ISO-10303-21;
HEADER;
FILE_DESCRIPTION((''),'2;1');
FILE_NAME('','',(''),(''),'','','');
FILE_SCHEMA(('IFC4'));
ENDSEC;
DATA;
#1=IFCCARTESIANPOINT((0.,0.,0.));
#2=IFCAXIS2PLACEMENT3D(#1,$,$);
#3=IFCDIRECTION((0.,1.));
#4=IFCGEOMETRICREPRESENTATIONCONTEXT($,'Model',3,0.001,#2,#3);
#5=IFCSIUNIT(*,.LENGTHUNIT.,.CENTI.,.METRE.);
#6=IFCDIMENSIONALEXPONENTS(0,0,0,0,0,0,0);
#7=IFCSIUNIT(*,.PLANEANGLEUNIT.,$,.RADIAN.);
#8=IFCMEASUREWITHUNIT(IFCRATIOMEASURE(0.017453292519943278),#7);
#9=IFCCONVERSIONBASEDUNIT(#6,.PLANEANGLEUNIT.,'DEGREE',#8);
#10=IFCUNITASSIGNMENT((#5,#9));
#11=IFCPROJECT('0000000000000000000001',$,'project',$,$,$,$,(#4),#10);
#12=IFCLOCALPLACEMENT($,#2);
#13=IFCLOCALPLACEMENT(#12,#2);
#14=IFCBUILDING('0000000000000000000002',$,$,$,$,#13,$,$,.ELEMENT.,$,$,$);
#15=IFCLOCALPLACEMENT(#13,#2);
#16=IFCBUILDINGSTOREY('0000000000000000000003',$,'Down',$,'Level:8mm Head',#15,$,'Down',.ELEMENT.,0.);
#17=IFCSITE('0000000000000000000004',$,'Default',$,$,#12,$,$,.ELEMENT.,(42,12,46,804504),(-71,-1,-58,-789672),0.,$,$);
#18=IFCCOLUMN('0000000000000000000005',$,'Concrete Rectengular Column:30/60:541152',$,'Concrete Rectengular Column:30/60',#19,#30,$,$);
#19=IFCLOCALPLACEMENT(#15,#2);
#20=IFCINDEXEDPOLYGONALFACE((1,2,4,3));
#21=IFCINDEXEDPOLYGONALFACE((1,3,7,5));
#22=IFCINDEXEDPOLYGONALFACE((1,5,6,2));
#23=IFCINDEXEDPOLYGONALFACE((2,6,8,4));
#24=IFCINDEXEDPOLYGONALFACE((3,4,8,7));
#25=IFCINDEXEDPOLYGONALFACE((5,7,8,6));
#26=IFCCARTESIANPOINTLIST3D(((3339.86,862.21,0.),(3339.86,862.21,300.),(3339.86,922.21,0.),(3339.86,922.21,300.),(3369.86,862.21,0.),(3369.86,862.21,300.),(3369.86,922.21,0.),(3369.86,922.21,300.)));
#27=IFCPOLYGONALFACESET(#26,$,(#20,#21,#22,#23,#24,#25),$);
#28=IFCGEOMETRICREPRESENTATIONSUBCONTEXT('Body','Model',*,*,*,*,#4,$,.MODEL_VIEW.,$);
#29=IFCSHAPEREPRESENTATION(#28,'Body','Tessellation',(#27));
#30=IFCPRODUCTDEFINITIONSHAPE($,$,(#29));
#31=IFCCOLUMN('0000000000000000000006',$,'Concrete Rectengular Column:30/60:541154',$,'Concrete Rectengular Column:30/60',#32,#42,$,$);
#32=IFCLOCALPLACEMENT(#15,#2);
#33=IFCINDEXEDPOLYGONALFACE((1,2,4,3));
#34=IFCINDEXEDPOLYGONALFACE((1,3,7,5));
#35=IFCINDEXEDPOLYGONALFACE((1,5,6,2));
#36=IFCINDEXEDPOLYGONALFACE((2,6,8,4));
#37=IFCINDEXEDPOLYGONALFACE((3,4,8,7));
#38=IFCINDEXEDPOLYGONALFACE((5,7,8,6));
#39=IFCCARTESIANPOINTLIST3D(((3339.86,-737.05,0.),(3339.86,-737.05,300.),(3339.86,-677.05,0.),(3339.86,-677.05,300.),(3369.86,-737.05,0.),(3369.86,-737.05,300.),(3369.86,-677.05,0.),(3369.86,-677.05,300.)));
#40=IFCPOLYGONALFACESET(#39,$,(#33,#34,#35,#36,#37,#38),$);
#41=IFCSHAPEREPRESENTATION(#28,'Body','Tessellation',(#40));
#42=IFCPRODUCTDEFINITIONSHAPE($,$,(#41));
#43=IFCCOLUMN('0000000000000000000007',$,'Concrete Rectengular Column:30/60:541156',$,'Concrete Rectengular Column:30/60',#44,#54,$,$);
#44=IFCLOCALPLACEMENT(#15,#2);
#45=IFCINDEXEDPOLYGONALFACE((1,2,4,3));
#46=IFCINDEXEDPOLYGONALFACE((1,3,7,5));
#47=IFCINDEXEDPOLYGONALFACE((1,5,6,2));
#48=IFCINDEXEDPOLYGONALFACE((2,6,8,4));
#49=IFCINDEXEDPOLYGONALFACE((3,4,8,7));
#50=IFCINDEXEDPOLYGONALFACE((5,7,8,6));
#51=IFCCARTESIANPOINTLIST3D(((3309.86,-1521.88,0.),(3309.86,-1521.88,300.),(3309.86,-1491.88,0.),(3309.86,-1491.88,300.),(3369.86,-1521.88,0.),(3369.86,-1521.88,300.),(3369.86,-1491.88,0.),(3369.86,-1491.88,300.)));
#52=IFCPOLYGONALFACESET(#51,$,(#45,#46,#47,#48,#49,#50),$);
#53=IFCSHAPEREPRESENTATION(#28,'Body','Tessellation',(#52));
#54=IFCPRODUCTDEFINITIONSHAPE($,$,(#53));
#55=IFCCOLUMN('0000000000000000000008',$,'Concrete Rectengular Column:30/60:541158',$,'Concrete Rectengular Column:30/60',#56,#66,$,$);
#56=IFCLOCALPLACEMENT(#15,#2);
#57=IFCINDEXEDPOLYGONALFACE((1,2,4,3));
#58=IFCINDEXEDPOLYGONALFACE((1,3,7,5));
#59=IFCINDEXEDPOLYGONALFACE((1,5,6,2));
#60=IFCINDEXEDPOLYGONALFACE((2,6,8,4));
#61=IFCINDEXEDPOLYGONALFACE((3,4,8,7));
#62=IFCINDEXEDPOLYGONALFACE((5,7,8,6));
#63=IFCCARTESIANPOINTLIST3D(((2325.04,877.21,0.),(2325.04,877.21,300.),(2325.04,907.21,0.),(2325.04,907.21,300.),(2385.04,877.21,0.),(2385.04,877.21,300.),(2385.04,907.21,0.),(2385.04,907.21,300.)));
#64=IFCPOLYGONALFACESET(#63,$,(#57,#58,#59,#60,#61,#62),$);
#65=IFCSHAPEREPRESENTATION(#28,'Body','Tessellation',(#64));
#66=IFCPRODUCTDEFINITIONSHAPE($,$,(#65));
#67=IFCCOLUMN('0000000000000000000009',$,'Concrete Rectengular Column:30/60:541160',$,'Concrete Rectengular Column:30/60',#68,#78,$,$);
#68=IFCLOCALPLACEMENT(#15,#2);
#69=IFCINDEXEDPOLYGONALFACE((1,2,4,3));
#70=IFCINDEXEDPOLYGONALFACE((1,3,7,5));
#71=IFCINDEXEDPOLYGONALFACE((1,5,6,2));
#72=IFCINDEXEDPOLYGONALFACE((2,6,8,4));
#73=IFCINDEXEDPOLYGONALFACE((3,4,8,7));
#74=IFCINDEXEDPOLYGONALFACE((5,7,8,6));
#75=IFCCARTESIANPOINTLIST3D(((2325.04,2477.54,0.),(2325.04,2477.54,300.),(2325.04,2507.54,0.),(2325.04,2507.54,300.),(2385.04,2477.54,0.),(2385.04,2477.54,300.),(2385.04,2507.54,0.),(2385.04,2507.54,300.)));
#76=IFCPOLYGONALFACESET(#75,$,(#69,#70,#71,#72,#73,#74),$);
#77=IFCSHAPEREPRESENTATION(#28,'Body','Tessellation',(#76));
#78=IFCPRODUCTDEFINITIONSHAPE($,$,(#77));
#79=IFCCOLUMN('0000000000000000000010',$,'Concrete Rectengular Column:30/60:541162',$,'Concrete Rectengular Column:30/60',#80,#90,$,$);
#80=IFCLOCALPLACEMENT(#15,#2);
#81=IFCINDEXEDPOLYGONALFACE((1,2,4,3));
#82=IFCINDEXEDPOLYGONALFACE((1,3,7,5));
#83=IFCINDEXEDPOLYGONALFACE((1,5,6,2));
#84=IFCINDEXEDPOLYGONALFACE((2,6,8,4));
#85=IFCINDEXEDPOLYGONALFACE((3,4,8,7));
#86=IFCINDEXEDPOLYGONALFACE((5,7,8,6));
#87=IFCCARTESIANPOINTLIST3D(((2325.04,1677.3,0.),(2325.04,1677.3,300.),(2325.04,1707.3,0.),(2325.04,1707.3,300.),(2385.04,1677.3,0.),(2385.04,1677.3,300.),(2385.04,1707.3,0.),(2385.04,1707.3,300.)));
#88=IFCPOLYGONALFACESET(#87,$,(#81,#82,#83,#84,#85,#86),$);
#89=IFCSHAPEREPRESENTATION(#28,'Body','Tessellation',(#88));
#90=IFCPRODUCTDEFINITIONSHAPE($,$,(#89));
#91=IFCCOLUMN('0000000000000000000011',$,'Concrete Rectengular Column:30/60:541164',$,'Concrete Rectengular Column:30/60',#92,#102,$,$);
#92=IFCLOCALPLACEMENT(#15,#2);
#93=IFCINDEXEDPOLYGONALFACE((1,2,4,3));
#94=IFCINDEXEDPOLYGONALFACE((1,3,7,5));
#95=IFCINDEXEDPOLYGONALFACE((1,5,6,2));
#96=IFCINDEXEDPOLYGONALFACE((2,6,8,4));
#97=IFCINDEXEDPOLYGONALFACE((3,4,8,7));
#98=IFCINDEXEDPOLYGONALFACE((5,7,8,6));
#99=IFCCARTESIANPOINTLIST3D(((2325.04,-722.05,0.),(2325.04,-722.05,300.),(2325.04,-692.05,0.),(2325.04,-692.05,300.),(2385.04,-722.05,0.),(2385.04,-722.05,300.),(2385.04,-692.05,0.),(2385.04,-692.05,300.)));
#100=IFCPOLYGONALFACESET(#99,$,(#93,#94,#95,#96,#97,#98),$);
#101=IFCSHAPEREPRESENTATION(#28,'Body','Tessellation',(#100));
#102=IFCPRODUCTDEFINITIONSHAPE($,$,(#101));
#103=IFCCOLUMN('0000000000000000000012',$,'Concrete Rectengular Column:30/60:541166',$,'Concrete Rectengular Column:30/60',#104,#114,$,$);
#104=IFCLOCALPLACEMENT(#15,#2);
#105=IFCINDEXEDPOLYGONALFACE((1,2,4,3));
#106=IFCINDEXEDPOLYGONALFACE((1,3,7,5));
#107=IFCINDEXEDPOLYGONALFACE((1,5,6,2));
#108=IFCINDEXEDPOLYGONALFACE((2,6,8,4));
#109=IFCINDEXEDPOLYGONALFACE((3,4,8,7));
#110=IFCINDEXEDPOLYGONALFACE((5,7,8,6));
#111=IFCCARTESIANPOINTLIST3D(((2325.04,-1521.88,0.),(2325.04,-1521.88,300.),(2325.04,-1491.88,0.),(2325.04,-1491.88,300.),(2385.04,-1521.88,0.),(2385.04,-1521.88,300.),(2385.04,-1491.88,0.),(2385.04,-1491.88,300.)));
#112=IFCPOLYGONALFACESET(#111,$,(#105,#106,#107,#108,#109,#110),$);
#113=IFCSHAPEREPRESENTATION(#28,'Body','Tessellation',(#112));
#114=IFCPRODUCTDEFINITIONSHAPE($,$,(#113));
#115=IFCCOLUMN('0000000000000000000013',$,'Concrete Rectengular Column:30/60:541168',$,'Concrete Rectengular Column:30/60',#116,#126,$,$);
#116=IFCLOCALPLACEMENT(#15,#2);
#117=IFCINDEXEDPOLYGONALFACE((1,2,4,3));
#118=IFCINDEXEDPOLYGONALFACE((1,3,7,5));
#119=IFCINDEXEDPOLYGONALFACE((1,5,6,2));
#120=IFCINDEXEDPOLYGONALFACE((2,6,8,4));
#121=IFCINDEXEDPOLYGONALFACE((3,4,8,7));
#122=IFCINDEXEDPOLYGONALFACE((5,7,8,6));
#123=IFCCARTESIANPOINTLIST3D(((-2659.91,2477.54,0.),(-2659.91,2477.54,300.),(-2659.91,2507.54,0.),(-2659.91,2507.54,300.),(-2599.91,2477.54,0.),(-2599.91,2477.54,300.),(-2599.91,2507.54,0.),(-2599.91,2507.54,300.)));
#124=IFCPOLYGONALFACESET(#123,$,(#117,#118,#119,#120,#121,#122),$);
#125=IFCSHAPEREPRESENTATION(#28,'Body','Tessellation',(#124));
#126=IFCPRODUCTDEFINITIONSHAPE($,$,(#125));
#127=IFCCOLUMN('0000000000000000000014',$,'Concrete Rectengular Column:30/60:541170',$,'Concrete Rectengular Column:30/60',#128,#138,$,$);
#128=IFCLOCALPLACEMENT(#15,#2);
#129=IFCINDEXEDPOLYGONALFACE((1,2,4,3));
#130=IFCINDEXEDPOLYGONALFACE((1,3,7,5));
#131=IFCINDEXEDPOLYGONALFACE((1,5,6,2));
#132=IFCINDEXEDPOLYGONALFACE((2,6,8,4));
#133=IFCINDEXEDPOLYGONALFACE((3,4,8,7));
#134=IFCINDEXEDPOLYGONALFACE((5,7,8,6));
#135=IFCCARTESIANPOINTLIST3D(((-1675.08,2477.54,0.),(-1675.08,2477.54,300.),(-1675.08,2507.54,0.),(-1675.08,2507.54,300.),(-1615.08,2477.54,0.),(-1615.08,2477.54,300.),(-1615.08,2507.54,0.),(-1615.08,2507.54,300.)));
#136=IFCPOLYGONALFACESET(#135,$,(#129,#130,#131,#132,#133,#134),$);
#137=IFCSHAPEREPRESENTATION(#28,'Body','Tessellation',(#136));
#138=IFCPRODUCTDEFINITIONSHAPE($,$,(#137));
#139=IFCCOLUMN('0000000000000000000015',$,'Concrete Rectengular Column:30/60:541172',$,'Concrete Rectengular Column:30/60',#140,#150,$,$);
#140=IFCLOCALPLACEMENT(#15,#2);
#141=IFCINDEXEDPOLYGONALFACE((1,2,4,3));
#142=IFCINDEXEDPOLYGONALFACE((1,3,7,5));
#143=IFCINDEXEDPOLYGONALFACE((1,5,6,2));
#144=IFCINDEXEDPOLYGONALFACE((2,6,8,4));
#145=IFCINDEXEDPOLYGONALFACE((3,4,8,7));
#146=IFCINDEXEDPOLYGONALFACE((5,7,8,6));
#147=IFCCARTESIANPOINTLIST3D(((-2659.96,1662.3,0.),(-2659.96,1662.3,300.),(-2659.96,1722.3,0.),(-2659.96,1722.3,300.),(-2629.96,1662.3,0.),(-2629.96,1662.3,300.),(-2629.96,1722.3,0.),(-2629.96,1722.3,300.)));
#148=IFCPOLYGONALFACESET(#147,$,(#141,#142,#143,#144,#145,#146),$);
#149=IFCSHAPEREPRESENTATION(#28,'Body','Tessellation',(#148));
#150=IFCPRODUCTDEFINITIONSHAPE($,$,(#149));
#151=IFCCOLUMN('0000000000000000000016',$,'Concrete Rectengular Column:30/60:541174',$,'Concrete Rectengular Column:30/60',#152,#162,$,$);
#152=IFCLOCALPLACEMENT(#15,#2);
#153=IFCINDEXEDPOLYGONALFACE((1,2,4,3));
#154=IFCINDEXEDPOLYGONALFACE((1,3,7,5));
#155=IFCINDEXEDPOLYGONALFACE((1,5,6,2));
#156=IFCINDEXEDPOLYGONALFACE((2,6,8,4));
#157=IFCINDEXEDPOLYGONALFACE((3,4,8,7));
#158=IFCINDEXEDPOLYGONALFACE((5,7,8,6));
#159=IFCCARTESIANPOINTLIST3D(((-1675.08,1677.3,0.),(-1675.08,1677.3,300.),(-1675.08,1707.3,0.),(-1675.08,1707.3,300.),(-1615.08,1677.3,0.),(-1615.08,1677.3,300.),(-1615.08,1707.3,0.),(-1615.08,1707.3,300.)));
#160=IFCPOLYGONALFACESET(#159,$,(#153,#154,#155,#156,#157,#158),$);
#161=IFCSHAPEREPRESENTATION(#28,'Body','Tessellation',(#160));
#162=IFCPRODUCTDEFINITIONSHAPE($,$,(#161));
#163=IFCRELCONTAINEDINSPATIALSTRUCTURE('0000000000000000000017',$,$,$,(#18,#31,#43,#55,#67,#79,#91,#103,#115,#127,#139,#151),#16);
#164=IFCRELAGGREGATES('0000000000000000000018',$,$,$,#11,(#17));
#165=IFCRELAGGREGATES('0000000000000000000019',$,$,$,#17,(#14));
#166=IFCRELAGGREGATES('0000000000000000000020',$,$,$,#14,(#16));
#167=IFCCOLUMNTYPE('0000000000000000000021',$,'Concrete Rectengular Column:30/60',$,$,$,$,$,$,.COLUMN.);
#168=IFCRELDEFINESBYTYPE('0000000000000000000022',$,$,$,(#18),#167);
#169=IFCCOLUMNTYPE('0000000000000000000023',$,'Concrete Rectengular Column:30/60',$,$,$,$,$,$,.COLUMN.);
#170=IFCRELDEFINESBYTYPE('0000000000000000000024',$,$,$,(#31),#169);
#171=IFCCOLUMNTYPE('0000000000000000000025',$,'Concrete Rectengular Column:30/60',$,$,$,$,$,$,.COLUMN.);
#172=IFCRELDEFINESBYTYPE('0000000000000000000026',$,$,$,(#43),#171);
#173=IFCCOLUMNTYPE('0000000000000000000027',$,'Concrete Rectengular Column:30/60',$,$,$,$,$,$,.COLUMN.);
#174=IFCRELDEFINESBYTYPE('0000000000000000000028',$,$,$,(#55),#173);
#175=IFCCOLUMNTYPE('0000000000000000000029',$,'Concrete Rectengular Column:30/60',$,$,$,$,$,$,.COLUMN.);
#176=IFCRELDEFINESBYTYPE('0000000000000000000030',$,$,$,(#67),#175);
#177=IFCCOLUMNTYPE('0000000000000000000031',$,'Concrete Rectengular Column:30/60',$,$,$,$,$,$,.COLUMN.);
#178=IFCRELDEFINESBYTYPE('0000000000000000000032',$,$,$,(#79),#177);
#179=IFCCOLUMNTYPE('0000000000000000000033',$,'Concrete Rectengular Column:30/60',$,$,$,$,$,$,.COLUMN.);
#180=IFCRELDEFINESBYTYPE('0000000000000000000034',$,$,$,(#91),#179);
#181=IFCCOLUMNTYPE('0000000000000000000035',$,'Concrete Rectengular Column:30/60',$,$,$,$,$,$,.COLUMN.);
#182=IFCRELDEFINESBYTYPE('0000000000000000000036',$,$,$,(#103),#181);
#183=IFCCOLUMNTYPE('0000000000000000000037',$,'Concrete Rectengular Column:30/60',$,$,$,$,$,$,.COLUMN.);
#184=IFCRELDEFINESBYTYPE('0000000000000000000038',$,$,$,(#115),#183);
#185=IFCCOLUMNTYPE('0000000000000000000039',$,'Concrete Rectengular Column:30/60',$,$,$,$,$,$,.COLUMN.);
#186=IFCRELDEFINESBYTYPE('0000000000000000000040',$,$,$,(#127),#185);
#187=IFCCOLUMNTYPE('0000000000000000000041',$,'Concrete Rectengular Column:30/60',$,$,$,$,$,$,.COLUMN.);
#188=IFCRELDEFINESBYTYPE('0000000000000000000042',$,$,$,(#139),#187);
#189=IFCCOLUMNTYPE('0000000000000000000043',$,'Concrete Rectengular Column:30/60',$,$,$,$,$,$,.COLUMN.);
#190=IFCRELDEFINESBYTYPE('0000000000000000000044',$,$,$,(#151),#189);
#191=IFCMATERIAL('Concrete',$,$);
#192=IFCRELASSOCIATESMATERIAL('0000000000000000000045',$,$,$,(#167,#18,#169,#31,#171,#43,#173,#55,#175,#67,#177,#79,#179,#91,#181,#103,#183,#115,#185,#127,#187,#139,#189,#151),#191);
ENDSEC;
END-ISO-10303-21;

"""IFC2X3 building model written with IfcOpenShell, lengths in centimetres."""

from ifc_helpers import new_model, entity, si_unit, converted_unit, direction, frame, frame_2d, origin, origin_2d_with_axis, place, context, subcontext, project, spatial, rectangle, extrude, source, transform, mapped, material, type_object, type_shapes, element, save


model = new_model("IFC2X3")

# Units and contexts
model_context = context("Model", 3, precision=0.001, world=origin(), true_north=direction((0.0, 1.0)))
body_context = subcontext(model_context, "Body", "Model", "MODEL_VIEW")
ifc_project = project(units=[si_unit("LENGTHUNIT", "METRE", prefix="CENTI"), converted_unit("PLANEANGLEUNIT", "DEGREE", entity("IfcRatioMeasure", 0.017453292519943278), si_unit("PLANEANGLEUNIT", "RADIAN"), dimensions=[0, 0, 0, 0, 0, 0, 0])], contexts=[model_context])

# Site, building, storey
site_placement = place(None, origin())
site = spatial("IfcSite", under=ifc_project, at=site_placement, Name="Default", CompositionType="ELEMENT", RefLatitude=(42, 12, 46, 804504), RefLongitude=(-71, -1, -58, -789672), RefElevation=0.0)
building_placement = place(site_placement, origin())
building = spatial("IfcBuilding", under=site, at=building_placement, CompositionType="ELEMENT")
storey_placement = place(building_placement, origin())
storey = spatial("IfcBuildingStorey", under=building, at=storey_placement, Name="Down", ObjectType="Level:8mm Head", LongName="Down", CompositionType="ELEMENT", Elevation=0.0)

# Columns
ifc_material = material(Name="Concrete")
column_type_1 = type_object("IfcColumnType", Name="Concrete Rectengular Column:30/60", PredefinedType="COLUMN", material=ifc_material)
shared_shape_1 = source(origin(), body_context, "Body", "SweptSolid", [
    extrude(rectangle(XDim=60.0, YDim=30.0, at=origin_2d_with_axis()), frame((3354.86, 892.21, 0.0), z_axis=(0.0, 0.0, 1.0), x_axis=(0.0, -1.0, 0.0)), (0.0, 0.0, 1.0), 300.0),
])
type_shapes(column_type_1, [shared_shape_1])
column_1_placement = place(storey_placement, origin())
element("IfcColumn", 1, at=column_1_placement, inside=storey, type_object=column_type_1, material=ifc_material, Name="Concrete Rectengular Column:30/60:541152", ObjectType="Concrete Rectengular Column:30/60", context=body_context, shape_type="MappedRepresentation", body=[
    mapped(shared_shape_1, transform((0.0, 0.0, 0.0), scale=1.0)),
])
column_type_2 = type_object("IfcColumnType", Name="Concrete Rectengular Column:30/60", PredefinedType="COLUMN", material=ifc_material)
shared_shape_2 = source(origin(), body_context, "Body", "SweptSolid", [
    extrude(rectangle(XDim=60.0, YDim=30.0, at=origin_2d_with_axis()), frame((3354.86, -707.05, 0.0), z_axis=(0.0, 0.0, 1.0), x_axis=(0.0, -1.0, 0.0)), (0.0, 0.0, 1.0), 300.0),
])
type_shapes(column_type_2, [shared_shape_2])
column_2_placement = place(storey_placement, origin())
element("IfcColumn", 2, at=column_2_placement, inside=storey, type_object=column_type_2, material=ifc_material, Name="Concrete Rectengular Column:30/60:541154", ObjectType="Concrete Rectengular Column:30/60", context=body_context, shape_type="MappedRepresentation", body=[
    mapped(shared_shape_2, transform((0.0, 0.0, 0.0), scale=1.0)),
])
column_type_3 = type_object("IfcColumnType", Name="Concrete Rectengular Column:30/60", PredefinedType="COLUMN", material=ifc_material)
shared_shape_3 = source(origin(), body_context, "Body", "SweptSolid", [
    extrude(rectangle(XDim=30.0, YDim=60.0, at=origin_2d_with_axis()), frame((3339.86, -1506.88, 0.0), z_axis=(0.0, 0.0, 1.0), x_axis=(0.0, -1.0, 0.0)), (0.0, 0.0, 1.0), 300.0),
])
type_shapes(column_type_3, [shared_shape_3])
column_3_placement = place(storey_placement, origin())
element("IfcColumn", 3, at=column_3_placement, inside=storey, type_object=column_type_3, material=ifc_material, Name="Concrete Rectengular Column:30/60:541156", ObjectType="Concrete Rectengular Column:30/60", context=body_context, shape_type="MappedRepresentation", body=[
    mapped(shared_shape_3, transform((0.0, 0.0, 0.0), scale=1.0)),
])
column_type_4 = type_object("IfcColumnType", Name="Concrete Rectengular Column:30/60", PredefinedType="COLUMN", material=ifc_material)
shared_shape_4 = source(origin(), body_context, "Body", "SweptSolid", [
    extrude(rectangle(XDim=30.0, YDim=60.0, at=frame_2d((0.0, 0.0), x_axis=(1.0, 0.0))), frame((2355.04, 892.21, 0.0), z_axis=(0.0, 0.0, 1.0), x_axis=(0.0, -1.0, 0.0)), (0.0, 0.0, 1.0), 300.0),
])
type_shapes(column_type_4, [shared_shape_4])
column_4_placement = place(storey_placement, origin())
element("IfcColumn", 4, at=column_4_placement, inside=storey, type_object=column_type_4, material=ifc_material, Name="Concrete Rectengular Column:30/60:541158", ObjectType="Concrete Rectengular Column:30/60", context=body_context, shape_type="MappedRepresentation", body=[
    mapped(shared_shape_4, transform((0.0, 0.0, 0.0), scale=1.0)),
])
column_type_5 = type_object("IfcColumnType", Name="Concrete Rectengular Column:30/60", PredefinedType="COLUMN", material=ifc_material)
shared_shape_5 = source(origin(), body_context, "Body", "SweptSolid", [
    extrude(rectangle(XDim=30.0, YDim=60.0, at=origin_2d_with_axis()), frame((2355.04, 2492.54, 0.0), z_axis=(0.0, 0.0, 1.0), x_axis=(0.0, -1.0, 0.0)), (0.0, 0.0, 1.0), 300.0),
])
type_shapes(column_type_5, [shared_shape_5])
column_5_placement = place(storey_placement, origin())
element("IfcColumn", 5, at=column_5_placement, inside=storey, type_object=column_type_5, material=ifc_material, Name="Concrete Rectengular Column:30/60:541160", ObjectType="Concrete Rectengular Column:30/60", context=body_context, shape_type="MappedRepresentation", body=[
    mapped(shared_shape_5, transform((0.0, 0.0, 0.0), scale=1.0)),
])
column_type_6 = type_object("IfcColumnType", Name="Concrete Rectengular Column:30/60", PredefinedType="COLUMN", material=ifc_material)
shared_shape_6 = source(origin(), body_context, "Body", "SweptSolid", [
    extrude(rectangle(XDim=30.0, YDim=60.0, at=origin_2d_with_axis()), frame((2355.04, 1692.3, 0.0), z_axis=(0.0, 0.0, 1.0), x_axis=(0.0, -1.0, 0.0)), (0.0, 0.0, 1.0), 300.0),
])
type_shapes(column_type_6, [shared_shape_6])
column_6_placement = place(storey_placement, origin())
element("IfcColumn", 6, at=column_6_placement, inside=storey, type_object=column_type_6, material=ifc_material, Name="Concrete Rectengular Column:30/60:541162", ObjectType="Concrete Rectengular Column:30/60", context=body_context, shape_type="MappedRepresentation", body=[
    mapped(shared_shape_6, transform((0.0, 0.0, 0.0), scale=1.0)),
])
column_type_7 = type_object("IfcColumnType", Name="Concrete Rectengular Column:30/60", PredefinedType="COLUMN", material=ifc_material)
shared_shape_7 = source(origin(), body_context, "Body", "SweptSolid", [
    extrude(rectangle(XDim=30.0, YDim=60.0, at=frame_2d((0.0, 0.0), x_axis=(1.0, 0.0))), frame((2355.04, -707.05, 0.0), z_axis=(0.0, 0.0, 1.0), x_axis=(0.0, -1.0, 0.0)), (0.0, 0.0, 1.0), 300.0),
])
type_shapes(column_type_7, [shared_shape_7])
column_7_placement = place(storey_placement, origin())
element("IfcColumn", 7, at=column_7_placement, inside=storey, type_object=column_type_7, material=ifc_material, Name="Concrete Rectengular Column:30/60:541164", ObjectType="Concrete Rectengular Column:30/60", context=body_context, shape_type="MappedRepresentation", body=[
    mapped(shared_shape_7, transform((0.0, 0.0, 0.0), scale=1.0)),
])
column_type_8 = type_object("IfcColumnType", Name="Concrete Rectengular Column:30/60", PredefinedType="COLUMN", material=ifc_material)
shared_shape_8 = source(origin(), body_context, "Body", "SweptSolid", [
    extrude(rectangle(XDim=30.0, YDim=60.0, at=origin_2d_with_axis()), frame((2355.04, -1506.88, 0.0), z_axis=(0.0, 0.0, 1.0), x_axis=(0.0, -1.0, 0.0)), (0.0, 0.0, 1.0), 300.0),
])
type_shapes(column_type_8, [shared_shape_8])
column_8_placement = place(storey_placement, origin())
element("IfcColumn", 8, at=column_8_placement, inside=storey, type_object=column_type_8, material=ifc_material, Name="Concrete Rectengular Column:30/60:541166", ObjectType="Concrete Rectengular Column:30/60", context=body_context, shape_type="MappedRepresentation", body=[
    mapped(shared_shape_8, transform((0.0, 0.0, 0.0), scale=1.0)),
])
column_type_9 = type_object("IfcColumnType", Name="Concrete Rectengular Column:30/60", PredefinedType="COLUMN", material=ifc_material)
shared_shape_9 = source(origin(), body_context, "Body", "SweptSolid", [
    extrude(rectangle(XDim=30.0, YDim=60.0, at=origin_2d_with_axis()), frame((-2629.91, 2492.54, 0.0), z_axis=(0.0, 0.0, 1.0), x_axis=(0.0, -1.0, 0.0)), (0.0, 0.0, 1.0), 300.0),
])
type_shapes(column_type_9, [shared_shape_9])
column_9_placement = place(storey_placement, origin())
element("IfcColumn", 9, at=column_9_placement, inside=storey, type_object=column_type_9, material=ifc_material, Name="Concrete Rectengular Column:30/60:541168", ObjectType="Concrete Rectengular Column:30/60", context=body_context, shape_type="MappedRepresentation", body=[
    mapped(shared_shape_9, transform((0.0, 0.0, 0.0), scale=1.0)),
])
column_type_10 = type_object("IfcColumnType", Name="Concrete Rectengular Column:30/60", PredefinedType="COLUMN", material=ifc_material)
shared_shape_10 = source(origin(), body_context, "Body", "SweptSolid", [
    extrude(rectangle(XDim=30.0, YDim=60.0, at=frame_2d((0.0, 0.0), x_axis=(1.0, 0.0))), frame((-1645.08, 2492.54, 0.0), z_axis=(0.0, 0.0, 1.0), x_axis=(0.0, -1.0, 0.0)), (0.0, 0.0, 1.0), 300.0),
])
type_shapes(column_type_10, [shared_shape_10])
column_10_placement = place(storey_placement, origin())
element("IfcColumn", 10, at=column_10_placement, inside=storey, type_object=column_type_10, material=ifc_material, Name="Concrete Rectengular Column:30/60:541170", ObjectType="Concrete Rectengular Column:30/60", context=body_context, shape_type="MappedRepresentation", body=[
    mapped(shared_shape_10, transform((0.0, 0.0, 0.0), scale=1.0)),
])
column_type_11 = type_object("IfcColumnType", Name="Concrete Rectengular Column:30/60", PredefinedType="COLUMN", material=ifc_material)
shared_shape_11 = source(origin(), body_context, "Body", "SweptSolid", [
    extrude(rectangle(XDim=60.0, YDim=30.0, at=origin_2d_with_axis()), frame((-2644.96, 1692.3, 0.0), z_axis=(0.0, 0.0, 1.0), x_axis=(0.0, -1.0, 0.0)), (0.0, 0.0, 1.0), 300.0),
])
type_shapes(column_type_11, [shared_shape_11])
column_11_placement = place(storey_placement, origin())
element("IfcColumn", 11, at=column_11_placement, inside=storey, type_object=column_type_11, material=ifc_material, Name="Concrete Rectengular Column:30/60:541172", ObjectType="Concrete Rectengular Column:30/60", context=body_context, shape_type="MappedRepresentation", body=[
    mapped(shared_shape_11, transform((0.0, 0.0, 0.0), scale=1.0)),
])
column_type_12 = type_object("IfcColumnType", Name="Concrete Rectengular Column:30/60", PredefinedType="COLUMN", material=ifc_material)
shared_shape_12 = source(origin(), body_context, "Body", "SweptSolid", [
    extrude(rectangle(XDim=30.0, YDim=60.0, at=frame_2d((0.0, 0.0), x_axis=(1.0, 0.0))), frame((-1645.08, 1692.3, 0.0), z_axis=(0.0, 0.0, 1.0), x_axis=(0.0, -1.0, 0.0)), (0.0, 0.0, 1.0), 300.0),
])
type_shapes(column_type_12, [shared_shape_12])
column_12_placement = place(storey_placement, origin())
element("IfcColumn", 12, at=column_12_placement, inside=storey, type_object=column_type_12, material=ifc_material, Name="Concrete Rectengular Column:30/60:541174", ObjectType="Concrete Rectengular Column:30/60", context=body_context, shape_type="MappedRepresentation", body=[
    mapped(shared_shape_12, transform((0.0, 0.0, 0.0), scale=1.0)),
])

save(model, "model.ifc")
